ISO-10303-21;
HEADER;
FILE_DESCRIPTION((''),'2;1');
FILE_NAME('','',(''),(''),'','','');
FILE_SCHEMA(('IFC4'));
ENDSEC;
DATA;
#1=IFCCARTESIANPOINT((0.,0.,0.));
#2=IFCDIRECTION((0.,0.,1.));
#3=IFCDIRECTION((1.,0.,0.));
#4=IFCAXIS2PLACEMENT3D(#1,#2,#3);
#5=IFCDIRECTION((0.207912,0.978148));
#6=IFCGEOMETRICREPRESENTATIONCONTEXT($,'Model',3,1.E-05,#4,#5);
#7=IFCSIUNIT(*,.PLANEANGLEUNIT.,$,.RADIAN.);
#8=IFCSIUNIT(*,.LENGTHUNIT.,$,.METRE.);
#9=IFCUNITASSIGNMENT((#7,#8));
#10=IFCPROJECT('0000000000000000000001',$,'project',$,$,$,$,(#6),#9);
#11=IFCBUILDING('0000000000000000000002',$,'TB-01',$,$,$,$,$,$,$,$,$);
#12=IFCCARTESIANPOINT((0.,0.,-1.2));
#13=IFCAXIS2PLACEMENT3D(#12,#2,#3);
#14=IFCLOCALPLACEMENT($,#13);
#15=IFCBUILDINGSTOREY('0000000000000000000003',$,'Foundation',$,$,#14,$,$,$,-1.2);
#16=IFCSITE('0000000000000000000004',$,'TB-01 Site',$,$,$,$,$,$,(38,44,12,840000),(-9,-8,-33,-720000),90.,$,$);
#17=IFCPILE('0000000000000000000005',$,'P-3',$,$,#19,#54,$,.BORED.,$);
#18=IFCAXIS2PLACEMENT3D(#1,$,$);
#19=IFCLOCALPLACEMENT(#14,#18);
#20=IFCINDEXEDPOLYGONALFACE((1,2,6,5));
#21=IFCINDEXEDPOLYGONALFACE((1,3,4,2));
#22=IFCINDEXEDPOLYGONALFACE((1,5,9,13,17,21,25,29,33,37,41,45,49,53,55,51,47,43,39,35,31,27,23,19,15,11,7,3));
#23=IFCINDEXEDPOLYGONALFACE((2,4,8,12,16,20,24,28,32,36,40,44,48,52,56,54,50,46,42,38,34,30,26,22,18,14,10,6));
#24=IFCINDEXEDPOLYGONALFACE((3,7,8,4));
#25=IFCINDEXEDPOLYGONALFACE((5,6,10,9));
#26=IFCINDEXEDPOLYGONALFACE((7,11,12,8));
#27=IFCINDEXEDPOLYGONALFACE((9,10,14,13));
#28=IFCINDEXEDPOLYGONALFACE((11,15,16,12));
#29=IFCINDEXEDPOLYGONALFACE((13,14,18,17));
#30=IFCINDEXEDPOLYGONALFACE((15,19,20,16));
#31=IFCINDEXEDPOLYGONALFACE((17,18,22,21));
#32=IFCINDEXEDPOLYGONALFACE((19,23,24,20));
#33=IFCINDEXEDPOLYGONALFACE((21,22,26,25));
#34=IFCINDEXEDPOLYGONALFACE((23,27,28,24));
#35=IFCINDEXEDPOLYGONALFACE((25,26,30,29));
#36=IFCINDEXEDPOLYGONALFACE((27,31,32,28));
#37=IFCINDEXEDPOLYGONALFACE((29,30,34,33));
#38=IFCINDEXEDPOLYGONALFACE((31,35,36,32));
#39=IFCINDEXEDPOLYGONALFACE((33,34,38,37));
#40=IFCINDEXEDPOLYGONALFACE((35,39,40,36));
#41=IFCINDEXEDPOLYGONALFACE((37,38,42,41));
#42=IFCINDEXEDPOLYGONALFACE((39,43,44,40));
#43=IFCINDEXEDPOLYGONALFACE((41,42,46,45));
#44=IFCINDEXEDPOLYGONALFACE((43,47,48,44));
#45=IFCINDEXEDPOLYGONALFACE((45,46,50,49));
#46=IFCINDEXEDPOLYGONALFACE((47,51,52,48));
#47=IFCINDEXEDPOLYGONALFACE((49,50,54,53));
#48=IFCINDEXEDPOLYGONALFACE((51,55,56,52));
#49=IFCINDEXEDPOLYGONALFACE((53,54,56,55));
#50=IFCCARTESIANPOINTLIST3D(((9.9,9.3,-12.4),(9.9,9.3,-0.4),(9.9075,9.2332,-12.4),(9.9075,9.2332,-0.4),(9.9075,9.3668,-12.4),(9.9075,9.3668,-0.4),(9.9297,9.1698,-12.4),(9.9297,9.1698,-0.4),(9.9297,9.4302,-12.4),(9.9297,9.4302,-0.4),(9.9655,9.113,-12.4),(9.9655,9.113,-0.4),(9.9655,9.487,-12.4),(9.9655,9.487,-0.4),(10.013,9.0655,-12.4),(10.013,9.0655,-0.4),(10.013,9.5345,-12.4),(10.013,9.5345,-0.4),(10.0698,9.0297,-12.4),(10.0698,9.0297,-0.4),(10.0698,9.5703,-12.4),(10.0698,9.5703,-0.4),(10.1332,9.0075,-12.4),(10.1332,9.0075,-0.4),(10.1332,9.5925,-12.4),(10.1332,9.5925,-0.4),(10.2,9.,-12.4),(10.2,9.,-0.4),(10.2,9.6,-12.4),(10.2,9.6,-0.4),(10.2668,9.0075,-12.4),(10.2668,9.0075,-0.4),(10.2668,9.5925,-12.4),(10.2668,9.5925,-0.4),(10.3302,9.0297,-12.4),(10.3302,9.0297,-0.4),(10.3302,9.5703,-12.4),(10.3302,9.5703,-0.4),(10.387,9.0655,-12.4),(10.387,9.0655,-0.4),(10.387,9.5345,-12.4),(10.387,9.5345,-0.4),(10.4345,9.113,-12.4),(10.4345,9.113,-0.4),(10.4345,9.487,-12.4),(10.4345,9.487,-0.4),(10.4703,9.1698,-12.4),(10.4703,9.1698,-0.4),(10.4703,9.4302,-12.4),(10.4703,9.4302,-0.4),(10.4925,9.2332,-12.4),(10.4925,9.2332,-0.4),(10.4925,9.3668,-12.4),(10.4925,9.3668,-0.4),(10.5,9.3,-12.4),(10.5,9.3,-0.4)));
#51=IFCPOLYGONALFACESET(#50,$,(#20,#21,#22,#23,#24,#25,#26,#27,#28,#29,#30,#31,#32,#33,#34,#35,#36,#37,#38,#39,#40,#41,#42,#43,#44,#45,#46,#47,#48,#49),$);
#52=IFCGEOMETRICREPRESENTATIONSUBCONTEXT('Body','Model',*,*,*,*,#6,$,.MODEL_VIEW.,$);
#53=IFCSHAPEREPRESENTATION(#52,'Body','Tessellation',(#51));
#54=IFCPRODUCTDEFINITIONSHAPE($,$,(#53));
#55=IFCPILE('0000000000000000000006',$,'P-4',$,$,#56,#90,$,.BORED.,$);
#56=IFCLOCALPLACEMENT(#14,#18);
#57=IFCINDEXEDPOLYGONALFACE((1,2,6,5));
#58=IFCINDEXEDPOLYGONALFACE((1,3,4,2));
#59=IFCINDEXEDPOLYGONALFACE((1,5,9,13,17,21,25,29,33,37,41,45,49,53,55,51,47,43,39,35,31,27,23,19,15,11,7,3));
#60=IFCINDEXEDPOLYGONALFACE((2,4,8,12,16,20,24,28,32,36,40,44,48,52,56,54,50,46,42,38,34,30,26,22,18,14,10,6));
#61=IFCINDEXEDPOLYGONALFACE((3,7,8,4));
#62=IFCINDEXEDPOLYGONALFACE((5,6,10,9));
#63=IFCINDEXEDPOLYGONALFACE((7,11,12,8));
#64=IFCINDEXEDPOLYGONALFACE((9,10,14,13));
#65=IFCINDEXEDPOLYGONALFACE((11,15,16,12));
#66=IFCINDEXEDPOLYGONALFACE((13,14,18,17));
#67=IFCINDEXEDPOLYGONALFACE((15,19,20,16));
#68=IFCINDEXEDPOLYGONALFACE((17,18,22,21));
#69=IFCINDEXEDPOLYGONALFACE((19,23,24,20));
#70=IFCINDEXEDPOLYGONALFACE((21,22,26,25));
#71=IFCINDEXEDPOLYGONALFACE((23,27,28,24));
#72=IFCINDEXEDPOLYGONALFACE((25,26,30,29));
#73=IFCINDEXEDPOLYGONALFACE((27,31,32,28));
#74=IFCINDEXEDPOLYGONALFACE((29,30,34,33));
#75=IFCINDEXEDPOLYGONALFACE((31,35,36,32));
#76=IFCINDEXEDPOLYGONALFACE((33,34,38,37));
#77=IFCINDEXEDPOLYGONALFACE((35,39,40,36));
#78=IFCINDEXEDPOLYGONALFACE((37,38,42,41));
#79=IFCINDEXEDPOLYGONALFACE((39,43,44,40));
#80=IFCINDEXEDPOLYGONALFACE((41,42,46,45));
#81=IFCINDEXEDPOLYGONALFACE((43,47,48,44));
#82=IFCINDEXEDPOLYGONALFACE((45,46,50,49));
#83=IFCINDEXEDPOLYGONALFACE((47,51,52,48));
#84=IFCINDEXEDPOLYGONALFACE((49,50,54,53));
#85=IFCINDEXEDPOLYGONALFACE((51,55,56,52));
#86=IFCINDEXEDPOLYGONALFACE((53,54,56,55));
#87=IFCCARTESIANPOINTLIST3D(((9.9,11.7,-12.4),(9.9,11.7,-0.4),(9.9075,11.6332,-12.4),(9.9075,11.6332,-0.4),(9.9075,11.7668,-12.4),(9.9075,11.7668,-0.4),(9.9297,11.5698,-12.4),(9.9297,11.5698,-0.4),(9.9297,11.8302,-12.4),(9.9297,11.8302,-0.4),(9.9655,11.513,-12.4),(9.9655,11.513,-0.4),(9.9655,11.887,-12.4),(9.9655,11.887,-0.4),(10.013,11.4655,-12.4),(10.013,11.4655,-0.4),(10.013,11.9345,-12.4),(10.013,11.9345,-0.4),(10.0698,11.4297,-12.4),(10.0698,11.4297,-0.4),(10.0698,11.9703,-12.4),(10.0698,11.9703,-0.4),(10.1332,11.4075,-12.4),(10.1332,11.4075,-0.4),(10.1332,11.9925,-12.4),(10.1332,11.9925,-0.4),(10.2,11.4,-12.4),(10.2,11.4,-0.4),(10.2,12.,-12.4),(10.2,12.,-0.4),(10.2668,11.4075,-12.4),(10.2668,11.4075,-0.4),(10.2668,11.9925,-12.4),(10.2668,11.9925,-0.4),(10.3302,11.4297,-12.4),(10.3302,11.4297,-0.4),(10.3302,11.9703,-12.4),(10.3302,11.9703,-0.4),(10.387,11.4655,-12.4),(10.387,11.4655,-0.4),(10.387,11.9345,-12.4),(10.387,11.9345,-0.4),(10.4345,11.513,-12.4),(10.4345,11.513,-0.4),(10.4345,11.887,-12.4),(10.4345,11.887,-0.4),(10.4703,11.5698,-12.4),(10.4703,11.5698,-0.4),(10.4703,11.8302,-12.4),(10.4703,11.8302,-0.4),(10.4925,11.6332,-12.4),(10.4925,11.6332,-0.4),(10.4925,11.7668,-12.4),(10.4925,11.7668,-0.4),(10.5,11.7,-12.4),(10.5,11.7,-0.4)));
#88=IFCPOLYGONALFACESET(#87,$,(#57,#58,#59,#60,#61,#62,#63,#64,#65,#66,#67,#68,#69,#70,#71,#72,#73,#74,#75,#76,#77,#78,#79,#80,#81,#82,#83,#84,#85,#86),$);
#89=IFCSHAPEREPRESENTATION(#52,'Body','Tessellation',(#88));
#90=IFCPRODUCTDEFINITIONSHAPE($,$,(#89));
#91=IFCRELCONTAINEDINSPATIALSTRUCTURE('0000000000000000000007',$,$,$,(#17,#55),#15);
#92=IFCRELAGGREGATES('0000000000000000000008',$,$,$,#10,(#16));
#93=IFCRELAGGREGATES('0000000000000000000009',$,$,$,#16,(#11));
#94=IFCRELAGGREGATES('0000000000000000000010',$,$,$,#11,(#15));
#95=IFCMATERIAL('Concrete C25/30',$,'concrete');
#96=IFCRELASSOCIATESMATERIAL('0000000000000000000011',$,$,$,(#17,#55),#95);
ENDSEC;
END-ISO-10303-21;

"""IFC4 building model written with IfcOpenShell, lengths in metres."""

from ifc_helpers import new_model, si_unit, direction, frame, origin_with_axes, place, context, subcontext, project, spatial, circle, extrude, material, element, save


model = new_model("IFC4")

# Units and contexts
model_context = context("Model", 3, precision=1e-05, world=origin_with_axes(), true_north=direction((0.207912, 0.978148)))
body_context = subcontext(model_context, "Body", "Model", "MODEL_VIEW")
ifc_project = project(units=[si_unit("PLANEANGLEUNIT", "RADIAN"), si_unit("LENGTHUNIT", "METRE")], contexts=[model_context])

# Site, building, storey
site = spatial("IfcSite", under=ifc_project, Name="TB-01 Site", RefLatitude=(38, 44, 12, 840000), RefLongitude=(-9, -8, -33, -720000), RefElevation=90.0)
building = spatial("IfcBuilding", under=site, Name="TB-01")
storey_placement = place(None, frame((0.0, 0.0, -1.2), z_axis=(0.0, 0.0, 1.0), x_axis=(1.0, 0.0, 0.0)))
storey = spatial("IfcBuildingStorey", under=building, at=storey_placement, Name="Foundation", Elevation=-1.2)

# Shared definitions
ifc_material_1 = material(Name="Concrete C25/30", Category="concrete")

# Piles
for number, where, z_axis, x_axis, name in (
    (1, (10.2, 9.3, -12.4), (0.0, 0.0, 1.0), (1.0, 0.0, 0.0), "P-3"),
    (2, (10.2, 11.7, -12.4), (0.0, 0.0, 1.0), (1.0, 0.0, 0.0), "P-4"),
):
    element("IfcPile", number, at=place(storey_placement, frame(where, z_axis=z_axis, x_axis=x_axis)), inside=storey, material=ifc_material_1, Name=name, PredefinedType="BORED", context=body_context, shape_type="SweptSolid", body=[
        extrude(circle(Radius=0.3), origin_with_axes(), (0.0, 0.0, 1.0), 12.0),
    ])

save(model, "model.ifc")
